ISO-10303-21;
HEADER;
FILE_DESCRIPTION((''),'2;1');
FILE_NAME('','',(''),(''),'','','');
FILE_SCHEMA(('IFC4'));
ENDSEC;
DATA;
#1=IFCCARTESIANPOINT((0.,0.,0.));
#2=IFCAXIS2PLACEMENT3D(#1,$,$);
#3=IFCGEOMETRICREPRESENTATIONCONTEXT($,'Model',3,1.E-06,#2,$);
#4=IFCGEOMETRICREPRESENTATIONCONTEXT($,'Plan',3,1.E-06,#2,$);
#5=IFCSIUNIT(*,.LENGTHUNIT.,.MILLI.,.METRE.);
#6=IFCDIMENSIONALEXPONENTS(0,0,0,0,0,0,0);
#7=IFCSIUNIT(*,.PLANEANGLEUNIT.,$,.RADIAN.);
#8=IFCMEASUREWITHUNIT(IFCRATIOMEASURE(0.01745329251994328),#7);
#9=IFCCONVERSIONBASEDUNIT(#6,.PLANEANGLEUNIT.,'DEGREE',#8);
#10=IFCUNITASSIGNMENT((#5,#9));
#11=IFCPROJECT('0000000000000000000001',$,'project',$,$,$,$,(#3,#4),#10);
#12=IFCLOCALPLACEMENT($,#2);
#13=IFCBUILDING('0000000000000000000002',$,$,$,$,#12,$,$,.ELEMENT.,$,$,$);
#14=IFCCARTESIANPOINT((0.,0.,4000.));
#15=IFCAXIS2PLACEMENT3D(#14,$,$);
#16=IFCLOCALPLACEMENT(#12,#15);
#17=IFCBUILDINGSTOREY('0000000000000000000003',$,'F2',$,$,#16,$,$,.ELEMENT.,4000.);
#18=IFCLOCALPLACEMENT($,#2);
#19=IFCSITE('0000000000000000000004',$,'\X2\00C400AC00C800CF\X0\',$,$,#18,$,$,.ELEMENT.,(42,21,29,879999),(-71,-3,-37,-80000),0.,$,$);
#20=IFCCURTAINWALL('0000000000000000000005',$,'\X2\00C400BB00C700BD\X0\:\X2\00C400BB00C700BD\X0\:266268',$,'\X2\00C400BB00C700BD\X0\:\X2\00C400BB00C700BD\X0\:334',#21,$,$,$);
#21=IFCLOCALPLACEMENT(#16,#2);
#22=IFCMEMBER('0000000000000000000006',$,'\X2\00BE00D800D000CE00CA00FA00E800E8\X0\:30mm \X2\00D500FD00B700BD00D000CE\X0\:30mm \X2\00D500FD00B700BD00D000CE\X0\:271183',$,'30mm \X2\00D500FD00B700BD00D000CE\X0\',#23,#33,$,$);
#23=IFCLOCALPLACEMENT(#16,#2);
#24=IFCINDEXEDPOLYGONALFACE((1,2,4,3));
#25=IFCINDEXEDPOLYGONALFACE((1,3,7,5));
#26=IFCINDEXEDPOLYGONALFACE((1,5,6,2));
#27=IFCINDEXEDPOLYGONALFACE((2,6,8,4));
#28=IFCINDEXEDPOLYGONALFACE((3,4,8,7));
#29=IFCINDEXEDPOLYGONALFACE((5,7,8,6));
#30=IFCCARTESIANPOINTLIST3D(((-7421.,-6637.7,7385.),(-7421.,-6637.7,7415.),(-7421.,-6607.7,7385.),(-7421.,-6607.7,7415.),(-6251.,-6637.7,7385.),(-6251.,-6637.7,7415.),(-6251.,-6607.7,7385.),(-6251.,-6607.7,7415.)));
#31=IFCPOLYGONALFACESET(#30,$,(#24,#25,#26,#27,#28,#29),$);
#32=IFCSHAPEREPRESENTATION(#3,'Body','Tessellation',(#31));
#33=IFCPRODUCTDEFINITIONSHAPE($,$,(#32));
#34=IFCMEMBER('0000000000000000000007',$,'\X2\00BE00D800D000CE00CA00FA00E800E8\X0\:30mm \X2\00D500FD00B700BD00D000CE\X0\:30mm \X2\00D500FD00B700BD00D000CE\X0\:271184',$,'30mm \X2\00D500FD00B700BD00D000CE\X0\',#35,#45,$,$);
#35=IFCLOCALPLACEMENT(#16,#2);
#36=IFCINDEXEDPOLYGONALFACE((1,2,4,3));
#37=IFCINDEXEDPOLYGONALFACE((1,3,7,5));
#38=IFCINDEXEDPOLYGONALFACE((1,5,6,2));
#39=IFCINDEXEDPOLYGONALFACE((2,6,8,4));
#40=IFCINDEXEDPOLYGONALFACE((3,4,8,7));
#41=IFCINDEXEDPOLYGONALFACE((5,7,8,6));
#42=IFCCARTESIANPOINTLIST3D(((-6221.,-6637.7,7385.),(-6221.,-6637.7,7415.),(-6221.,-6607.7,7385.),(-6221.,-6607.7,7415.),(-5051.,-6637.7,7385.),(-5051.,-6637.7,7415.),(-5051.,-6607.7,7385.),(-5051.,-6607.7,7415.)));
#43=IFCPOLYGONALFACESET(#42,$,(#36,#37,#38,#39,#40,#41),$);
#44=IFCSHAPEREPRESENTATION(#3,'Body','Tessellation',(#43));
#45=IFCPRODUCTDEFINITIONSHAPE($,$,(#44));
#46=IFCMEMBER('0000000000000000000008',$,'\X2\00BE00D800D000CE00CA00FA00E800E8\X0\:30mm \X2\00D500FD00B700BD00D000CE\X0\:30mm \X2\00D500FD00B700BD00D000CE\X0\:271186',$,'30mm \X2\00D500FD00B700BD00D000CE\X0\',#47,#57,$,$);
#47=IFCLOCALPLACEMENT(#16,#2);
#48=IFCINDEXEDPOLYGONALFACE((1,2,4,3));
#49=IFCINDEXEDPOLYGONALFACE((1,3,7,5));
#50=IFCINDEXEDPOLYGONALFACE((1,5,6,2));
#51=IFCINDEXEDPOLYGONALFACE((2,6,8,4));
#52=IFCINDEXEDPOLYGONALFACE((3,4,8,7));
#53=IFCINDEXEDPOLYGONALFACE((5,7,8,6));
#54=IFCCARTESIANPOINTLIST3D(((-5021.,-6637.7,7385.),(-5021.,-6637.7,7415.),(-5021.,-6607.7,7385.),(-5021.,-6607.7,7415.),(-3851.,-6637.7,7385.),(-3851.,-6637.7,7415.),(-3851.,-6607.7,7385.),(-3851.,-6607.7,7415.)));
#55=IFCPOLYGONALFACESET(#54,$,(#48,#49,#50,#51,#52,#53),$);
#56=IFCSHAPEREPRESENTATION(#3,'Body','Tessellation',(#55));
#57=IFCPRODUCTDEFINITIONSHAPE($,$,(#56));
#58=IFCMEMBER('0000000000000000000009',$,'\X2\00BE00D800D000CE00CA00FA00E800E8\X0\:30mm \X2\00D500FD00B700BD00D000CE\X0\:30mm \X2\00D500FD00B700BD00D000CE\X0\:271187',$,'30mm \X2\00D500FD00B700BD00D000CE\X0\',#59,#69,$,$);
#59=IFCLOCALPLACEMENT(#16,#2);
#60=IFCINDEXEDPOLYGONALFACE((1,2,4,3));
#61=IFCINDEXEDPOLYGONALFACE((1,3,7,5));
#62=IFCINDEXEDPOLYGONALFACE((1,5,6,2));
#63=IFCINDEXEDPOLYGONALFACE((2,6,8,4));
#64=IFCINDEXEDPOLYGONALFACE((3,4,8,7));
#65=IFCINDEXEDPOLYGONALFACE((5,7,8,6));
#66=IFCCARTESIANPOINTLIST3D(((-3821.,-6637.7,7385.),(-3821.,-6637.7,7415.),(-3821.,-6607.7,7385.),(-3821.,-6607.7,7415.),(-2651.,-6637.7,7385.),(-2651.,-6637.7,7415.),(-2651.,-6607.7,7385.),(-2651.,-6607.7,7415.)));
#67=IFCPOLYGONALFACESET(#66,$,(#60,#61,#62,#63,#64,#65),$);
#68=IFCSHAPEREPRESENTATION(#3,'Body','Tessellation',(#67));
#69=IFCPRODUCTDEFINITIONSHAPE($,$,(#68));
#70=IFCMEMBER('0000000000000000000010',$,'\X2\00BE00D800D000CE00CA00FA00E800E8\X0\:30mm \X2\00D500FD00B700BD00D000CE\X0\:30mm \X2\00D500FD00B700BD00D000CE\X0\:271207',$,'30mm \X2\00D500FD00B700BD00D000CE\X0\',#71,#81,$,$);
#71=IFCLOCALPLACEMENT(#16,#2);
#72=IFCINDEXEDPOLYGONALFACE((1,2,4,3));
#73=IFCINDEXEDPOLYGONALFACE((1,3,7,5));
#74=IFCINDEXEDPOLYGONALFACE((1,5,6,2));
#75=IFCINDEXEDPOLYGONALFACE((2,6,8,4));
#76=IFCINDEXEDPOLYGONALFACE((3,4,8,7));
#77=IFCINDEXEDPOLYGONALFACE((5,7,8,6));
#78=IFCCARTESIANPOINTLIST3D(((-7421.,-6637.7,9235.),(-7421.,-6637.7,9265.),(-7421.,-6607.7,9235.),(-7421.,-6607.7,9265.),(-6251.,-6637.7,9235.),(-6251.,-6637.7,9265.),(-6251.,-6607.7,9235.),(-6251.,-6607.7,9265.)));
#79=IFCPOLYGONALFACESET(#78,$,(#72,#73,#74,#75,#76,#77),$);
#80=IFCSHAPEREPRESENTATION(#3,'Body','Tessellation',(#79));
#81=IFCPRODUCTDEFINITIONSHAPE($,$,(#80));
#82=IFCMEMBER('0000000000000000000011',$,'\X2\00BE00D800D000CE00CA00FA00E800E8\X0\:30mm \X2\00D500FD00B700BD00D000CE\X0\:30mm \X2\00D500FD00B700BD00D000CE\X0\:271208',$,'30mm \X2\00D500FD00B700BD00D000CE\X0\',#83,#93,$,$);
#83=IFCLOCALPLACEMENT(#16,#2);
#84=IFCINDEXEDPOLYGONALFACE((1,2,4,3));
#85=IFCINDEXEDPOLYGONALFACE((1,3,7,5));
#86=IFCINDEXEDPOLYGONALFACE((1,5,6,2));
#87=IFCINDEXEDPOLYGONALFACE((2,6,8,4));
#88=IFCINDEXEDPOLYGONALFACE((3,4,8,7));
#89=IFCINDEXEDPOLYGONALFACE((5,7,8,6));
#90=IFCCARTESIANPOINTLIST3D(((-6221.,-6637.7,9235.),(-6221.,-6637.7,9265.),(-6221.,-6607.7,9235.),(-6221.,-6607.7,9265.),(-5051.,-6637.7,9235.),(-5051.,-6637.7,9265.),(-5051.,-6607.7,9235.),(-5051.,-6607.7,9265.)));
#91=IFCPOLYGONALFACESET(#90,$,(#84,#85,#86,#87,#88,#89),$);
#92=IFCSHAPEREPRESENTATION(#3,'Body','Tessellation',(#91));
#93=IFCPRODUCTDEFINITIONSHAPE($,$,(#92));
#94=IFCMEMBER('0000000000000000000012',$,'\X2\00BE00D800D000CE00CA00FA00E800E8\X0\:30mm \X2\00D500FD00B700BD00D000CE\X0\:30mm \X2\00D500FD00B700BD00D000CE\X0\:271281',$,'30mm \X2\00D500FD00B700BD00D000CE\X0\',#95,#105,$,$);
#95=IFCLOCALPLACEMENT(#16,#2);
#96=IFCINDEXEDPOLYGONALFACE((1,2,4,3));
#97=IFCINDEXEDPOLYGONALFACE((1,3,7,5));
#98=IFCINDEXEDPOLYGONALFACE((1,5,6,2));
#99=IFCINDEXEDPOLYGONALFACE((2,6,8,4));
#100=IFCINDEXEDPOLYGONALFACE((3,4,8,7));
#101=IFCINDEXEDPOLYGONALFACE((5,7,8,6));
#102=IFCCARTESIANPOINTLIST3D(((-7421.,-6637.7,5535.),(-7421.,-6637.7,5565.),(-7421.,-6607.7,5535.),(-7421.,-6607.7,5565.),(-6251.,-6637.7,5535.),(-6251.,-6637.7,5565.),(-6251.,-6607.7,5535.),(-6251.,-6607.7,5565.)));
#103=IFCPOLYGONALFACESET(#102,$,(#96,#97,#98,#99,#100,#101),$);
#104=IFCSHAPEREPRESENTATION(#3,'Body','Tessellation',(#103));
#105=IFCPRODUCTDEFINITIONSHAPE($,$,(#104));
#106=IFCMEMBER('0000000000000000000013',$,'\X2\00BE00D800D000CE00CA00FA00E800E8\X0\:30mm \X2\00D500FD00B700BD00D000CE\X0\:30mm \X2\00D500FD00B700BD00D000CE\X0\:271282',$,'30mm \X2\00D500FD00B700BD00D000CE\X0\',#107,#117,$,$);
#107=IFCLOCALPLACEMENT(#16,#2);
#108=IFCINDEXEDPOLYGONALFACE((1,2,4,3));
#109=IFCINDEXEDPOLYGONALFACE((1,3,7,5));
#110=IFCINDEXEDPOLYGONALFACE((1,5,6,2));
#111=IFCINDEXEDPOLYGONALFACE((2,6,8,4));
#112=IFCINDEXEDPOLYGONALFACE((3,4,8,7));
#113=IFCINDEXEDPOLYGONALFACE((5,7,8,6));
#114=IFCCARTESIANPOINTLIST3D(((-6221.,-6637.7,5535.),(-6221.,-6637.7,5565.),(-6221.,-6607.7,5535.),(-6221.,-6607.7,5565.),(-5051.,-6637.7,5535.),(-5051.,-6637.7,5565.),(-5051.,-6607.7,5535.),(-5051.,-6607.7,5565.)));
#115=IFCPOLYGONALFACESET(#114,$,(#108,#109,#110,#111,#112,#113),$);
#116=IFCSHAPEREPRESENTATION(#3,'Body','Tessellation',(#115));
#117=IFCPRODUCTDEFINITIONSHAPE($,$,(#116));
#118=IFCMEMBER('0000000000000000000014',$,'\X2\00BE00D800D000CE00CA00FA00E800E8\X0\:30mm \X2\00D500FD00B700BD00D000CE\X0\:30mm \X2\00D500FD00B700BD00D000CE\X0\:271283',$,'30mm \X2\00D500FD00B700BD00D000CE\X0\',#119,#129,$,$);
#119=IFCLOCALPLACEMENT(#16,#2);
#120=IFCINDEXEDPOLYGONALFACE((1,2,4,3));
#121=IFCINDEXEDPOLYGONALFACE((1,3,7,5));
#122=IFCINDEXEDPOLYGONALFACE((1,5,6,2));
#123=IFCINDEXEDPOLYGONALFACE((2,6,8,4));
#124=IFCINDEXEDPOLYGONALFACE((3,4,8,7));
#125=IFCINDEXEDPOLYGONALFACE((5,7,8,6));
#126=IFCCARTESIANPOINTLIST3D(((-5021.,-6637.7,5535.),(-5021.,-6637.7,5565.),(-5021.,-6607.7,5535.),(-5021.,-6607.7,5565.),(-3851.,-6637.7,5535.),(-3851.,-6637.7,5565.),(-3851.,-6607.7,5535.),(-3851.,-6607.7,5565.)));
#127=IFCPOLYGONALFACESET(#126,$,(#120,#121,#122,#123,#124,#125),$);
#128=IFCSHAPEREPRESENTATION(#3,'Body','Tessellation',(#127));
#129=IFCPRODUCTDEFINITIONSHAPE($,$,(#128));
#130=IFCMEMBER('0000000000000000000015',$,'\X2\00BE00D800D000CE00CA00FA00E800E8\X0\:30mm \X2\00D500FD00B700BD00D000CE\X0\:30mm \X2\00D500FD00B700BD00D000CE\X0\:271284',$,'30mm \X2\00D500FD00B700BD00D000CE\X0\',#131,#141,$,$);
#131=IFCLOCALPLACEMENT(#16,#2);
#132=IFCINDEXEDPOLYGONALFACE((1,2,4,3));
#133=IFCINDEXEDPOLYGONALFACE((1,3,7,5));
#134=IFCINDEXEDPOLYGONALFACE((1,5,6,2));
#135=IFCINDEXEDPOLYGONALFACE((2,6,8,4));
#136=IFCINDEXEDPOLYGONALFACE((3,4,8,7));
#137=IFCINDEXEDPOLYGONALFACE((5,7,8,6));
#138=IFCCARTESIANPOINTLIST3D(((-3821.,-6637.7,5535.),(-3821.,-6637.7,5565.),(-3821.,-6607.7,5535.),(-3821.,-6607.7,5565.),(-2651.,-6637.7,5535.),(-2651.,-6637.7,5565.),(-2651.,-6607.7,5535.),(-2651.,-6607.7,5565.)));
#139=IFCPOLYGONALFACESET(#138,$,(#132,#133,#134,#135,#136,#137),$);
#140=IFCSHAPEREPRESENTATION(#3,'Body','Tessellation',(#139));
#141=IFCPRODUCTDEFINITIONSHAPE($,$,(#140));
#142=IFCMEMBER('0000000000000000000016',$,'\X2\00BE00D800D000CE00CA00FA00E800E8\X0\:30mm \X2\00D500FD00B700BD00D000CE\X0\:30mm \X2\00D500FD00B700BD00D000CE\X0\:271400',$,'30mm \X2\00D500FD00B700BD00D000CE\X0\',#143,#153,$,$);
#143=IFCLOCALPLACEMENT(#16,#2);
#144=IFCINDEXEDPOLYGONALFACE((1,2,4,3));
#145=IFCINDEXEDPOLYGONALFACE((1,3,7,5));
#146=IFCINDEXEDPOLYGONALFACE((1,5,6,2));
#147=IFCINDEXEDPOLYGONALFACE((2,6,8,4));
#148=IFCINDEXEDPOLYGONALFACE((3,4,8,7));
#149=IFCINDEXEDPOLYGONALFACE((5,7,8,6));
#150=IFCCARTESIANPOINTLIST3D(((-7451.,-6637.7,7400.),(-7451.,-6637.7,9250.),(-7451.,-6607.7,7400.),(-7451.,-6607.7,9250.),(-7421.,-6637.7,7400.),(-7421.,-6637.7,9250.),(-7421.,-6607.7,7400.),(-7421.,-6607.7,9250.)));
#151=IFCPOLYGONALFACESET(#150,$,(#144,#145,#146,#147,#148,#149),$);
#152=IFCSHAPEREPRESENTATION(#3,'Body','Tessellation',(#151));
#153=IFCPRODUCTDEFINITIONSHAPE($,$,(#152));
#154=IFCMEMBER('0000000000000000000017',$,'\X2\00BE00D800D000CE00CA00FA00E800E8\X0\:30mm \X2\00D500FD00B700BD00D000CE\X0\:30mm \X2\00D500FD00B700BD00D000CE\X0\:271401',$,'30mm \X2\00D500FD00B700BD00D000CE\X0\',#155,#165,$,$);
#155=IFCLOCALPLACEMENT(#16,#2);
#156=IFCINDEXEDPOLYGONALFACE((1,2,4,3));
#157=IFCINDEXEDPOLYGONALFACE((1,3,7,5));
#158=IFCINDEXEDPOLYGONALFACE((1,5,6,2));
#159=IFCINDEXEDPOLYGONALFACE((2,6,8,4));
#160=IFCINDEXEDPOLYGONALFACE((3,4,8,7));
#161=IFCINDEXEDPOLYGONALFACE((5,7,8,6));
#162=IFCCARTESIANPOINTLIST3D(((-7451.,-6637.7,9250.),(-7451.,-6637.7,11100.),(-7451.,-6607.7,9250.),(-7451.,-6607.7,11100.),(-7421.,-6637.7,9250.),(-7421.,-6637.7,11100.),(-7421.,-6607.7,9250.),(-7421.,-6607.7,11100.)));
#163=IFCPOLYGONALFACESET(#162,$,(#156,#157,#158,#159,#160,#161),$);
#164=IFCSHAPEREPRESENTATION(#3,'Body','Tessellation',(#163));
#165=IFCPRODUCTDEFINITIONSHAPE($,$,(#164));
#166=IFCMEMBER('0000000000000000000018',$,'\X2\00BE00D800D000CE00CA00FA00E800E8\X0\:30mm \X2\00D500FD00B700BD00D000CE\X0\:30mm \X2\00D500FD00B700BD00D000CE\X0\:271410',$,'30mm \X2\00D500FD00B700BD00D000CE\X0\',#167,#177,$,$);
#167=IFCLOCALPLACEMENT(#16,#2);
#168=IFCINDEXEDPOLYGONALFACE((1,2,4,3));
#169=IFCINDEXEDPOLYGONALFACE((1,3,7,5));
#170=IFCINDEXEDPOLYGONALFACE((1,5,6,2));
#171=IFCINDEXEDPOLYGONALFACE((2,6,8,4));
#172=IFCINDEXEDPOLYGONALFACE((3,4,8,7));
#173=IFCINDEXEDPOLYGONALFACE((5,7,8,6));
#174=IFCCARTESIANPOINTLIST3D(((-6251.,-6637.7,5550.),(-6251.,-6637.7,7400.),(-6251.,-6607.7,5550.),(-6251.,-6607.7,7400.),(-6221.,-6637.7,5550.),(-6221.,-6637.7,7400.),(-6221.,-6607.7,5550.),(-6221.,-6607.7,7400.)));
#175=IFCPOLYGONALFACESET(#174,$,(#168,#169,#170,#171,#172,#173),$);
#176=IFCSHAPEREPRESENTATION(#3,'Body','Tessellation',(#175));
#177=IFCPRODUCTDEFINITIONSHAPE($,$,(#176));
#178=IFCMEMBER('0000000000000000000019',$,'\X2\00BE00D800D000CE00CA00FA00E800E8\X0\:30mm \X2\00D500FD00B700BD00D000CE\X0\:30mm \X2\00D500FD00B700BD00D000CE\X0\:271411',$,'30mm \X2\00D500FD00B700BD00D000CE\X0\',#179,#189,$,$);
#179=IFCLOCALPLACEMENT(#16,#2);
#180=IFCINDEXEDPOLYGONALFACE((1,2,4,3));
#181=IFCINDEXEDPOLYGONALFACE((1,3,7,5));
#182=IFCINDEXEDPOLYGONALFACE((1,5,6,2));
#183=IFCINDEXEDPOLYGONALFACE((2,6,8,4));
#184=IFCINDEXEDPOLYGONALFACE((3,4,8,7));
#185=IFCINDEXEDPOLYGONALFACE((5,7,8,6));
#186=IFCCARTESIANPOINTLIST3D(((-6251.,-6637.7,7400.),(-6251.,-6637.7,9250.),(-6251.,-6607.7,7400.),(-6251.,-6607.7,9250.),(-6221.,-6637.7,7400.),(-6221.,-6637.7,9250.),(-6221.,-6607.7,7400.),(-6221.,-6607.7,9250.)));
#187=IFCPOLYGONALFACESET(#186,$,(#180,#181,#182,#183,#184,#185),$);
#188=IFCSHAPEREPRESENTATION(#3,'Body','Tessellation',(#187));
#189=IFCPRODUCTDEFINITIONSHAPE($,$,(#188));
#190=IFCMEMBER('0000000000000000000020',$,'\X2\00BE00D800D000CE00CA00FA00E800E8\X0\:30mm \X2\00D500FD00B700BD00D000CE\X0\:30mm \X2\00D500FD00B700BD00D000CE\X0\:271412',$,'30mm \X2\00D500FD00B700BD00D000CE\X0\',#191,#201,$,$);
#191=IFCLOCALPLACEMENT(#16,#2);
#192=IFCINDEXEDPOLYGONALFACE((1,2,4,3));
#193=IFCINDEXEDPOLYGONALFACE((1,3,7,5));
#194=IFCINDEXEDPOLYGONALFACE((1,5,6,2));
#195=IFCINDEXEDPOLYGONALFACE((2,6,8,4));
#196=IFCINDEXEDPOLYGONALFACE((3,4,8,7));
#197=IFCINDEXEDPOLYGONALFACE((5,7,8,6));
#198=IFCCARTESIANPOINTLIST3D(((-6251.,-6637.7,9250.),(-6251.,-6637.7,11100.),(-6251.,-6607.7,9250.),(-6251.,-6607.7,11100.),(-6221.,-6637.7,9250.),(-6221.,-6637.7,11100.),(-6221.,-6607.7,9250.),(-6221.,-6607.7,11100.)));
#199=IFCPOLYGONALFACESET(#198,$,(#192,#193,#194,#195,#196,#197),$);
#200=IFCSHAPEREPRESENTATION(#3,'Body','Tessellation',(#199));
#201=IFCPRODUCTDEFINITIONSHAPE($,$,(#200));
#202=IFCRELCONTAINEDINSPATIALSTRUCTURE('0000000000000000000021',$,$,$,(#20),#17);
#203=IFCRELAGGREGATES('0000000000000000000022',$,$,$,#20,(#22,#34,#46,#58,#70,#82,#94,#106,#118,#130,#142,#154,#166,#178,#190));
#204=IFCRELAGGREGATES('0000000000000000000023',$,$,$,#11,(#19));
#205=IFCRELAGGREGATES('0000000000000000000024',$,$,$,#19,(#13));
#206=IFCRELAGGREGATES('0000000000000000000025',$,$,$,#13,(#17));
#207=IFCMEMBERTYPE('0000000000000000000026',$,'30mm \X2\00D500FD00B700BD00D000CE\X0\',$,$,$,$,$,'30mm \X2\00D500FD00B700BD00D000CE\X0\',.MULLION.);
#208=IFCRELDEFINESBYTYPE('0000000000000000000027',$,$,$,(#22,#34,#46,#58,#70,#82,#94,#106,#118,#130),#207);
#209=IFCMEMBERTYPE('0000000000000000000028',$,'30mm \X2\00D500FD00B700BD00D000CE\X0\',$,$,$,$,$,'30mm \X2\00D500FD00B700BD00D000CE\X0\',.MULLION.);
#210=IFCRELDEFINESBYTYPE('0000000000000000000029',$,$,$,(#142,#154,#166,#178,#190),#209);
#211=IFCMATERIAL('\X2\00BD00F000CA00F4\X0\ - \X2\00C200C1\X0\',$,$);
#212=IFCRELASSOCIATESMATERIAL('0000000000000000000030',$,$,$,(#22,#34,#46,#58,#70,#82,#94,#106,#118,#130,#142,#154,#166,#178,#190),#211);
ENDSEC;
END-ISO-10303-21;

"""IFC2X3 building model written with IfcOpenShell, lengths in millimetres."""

from ifc_helpers import new_model, entity, si_unit, converted_unit, frame, origin, origin_2d_with_axis, place, context, project, spatial, rectangle, extrude, source, transform, mapped, material, type_object, type_shapes, element, aggregate, save


model = new_model("IFC2X3")

# Units and contexts
model_context = context("Model", 3, precision=1e-06, world=origin())
plan_context = context("Plan", 3, precision=1e-06, world=origin())
ifc_project = project(units=[si_unit("LENGTHUNIT", "METRE", prefix="MILLI"), converted_unit("PLANEANGLEUNIT", "DEGREE", entity("IfcRatioMeasure", 0.01745329251994328), si_unit("PLANEANGLEUNIT", "RADIAN"), dimensions=[0, 0, 0, 0, 0, 0, 0])], contexts=[model_context, plan_context])

# Site, building, storey
site_placement = place(None, origin())
site = spatial("IfcSite", under=ifc_project, at=site_placement, Name="Ä¬ÈÏ", CompositionType="ELEMENT", RefLatitude=(42, 21, 29, 879999), RefLongitude=(-71, -3, -37, -80000), RefElevation=0.0)
building_placement = place(None, origin())
building = spatial("IfcBuilding", under=site, at=building_placement, CompositionType="ELEMENT")
storey_placement = place(building_placement, frame((0.0, 0.0, 4000.0)))
storey = spatial("IfcBuildingStorey", under=building, at=storey_placement, Name="F2", CompositionType="ELEMENT", Elevation=4000.0)

# Curtain wall, members
curtain_wall_placement = place(storey_placement, origin())
curtain_wall = element("IfcCurtainWall", 1, at=curtain_wall_placement, inside=storey, Name="Ä»Ç½:Ä»Ç½:266268", ObjectType="Ä»Ç½:Ä»Ç½:334")
ifc_material_1 = material(Name="½ðÊô - ÂÁ")
member_type_1 = type_object("IfcMemberType", Name="30mm Õý·½ÐÎ", ElementType="30mm Õý·½ÐÎ", PredefinedType="MULLION")
shared_shape_1 = source(origin(), model_context, "Body", "SweptSolid", [
    extrude(rectangle(XDim=30.0, YDim=30.0, at=origin_2d_with_axis()), frame((0.0, 0.0, -1170.0), z_axis=(0.0, 0.0, 1.0), x_axis=(-1.0, 0.0, 0.0)), (0.0, 0.0, 1.0), 1170.0),
])
type_shapes(member_type_1, [shared_shape_1])
placement_1 = place(building_placement, frame((0.0, 0.0, 11400.0)))
member_1_placement = place(placement_1, frame((-6251.0, -6622.7, 0.0), z_axis=(1.0, 0.0, 0.0), x_axis=(0.0, 0.0, 1.0)))
member_1 = element("IfcMember", 2, at=member_1_placement, type_object=member_type_1, material=ifc_material_1, Name="¾ØÐÎÊúèè:30mm Õý·½ÐÎ:30mm Õý·½ÐÎ:271183", ObjectType="30mm Õý·½ÐÎ", context=model_context, shape_type="MappedRepresentation", body=[
    mapped(shared_shape_1, transform((0.0, 0.0, 0.0), scale=1.0)),
])
member_2_placement = place(placement_1, frame((-5051.0, -6622.7, 0.0), z_axis=(1.0, 0.0, 0.0), x_axis=(0.0, 0.0, 1.0)))
member_2 = element("IfcMember", 3, at=member_2_placement, type_object=member_type_1, material=ifc_material_1, Name="¾ØÐÎÊúèè:30mm Õý·½ÐÎ:30mm Õý·½ÐÎ:271184", ObjectType="30mm Õý·½ÐÎ", context=model_context, shape_type="MappedRepresentation", body=[
    mapped(shared_shape_1, transform((0.0, 0.0, 0.0), scale=1.0)),
])
member_3_placement = place(placement_1, frame((-3851.0, -6622.7, 0.0), z_axis=(1.0, 0.0, 0.0), x_axis=(0.0, 0.0, 1.0)))
member_3 = element("IfcMember", 4, at=member_3_placement, type_object=member_type_1, material=ifc_material_1, Name="¾ØÐÎÊúèè:30mm Õý·½ÐÎ:30mm Õý·½ÐÎ:271186", ObjectType="30mm Õý·½ÐÎ", context=model_context, shape_type="MappedRepresentation", body=[
    mapped(shared_shape_1, transform((0.0, 0.0, 0.0), scale=1.0)),
])
member_4_placement = place(placement_1, frame((-2651.0, -6622.7, 0.0), z_axis=(1.0, 0.0, 0.0), x_axis=(0.0, 0.0, 1.0)))
member_4 = element("IfcMember", 5, at=member_4_placement, type_object=member_type_1, material=ifc_material_1, Name="¾ØÐÎÊúèè:30mm Õý·½ÐÎ:30mm Õý·½ÐÎ:271187", ObjectType="30mm Õý·½ÐÎ", context=model_context, shape_type="MappedRepresentation", body=[
    mapped(shared_shape_1, transform((0.0, 0.0, 0.0), scale=1.0)),
])
member_5_placement = place(placement_1, frame((-6251.0, -6622.7, 1850.0), z_axis=(1.0, 0.0, 0.0), x_axis=(0.0, 0.0, 1.0)))
member_5 = element("IfcMember", 6, at=member_5_placement, type_object=member_type_1, material=ifc_material_1, Name="¾ØÐÎÊúèè:30mm Õý·½ÐÎ:30mm Õý·½ÐÎ:271207", ObjectType="30mm Õý·½ÐÎ", context=model_context, shape_type="MappedRepresentation", body=[
    mapped(shared_shape_1, transform((0.0, 0.0, 0.0), scale=1.0)),
])
member_6_placement = place(placement_1, frame((-5051.0, -6622.7, 1850.0), z_axis=(1.0, 0.0, 0.0), x_axis=(0.0, 0.0, 1.0)))
member_6 = element("IfcMember", 7, at=member_6_placement, type_object=member_type_1, material=ifc_material_1, Name="¾ØÐÎÊúèè:30mm Õý·½ÐÎ:30mm Õý·½ÐÎ:271208", ObjectType="30mm Õý·½ÐÎ", context=model_context, shape_type="MappedRepresentation", body=[
    mapped(shared_shape_1, transform((0.0, 0.0, 0.0), scale=1.0)),
])
placement_2 = place(building_placement, frame((0.0, 0.0, 7700.0)))
member_7_placement = place(placement_2, frame((-6251.0, -6622.7, 1850.0), z_axis=(1.0, 0.0, 0.0), x_axis=(0.0, 0.0, 1.0)))
member_7 = element("IfcMember", 8, at=member_7_placement, type_object=member_type_1, material=ifc_material_1, Name="¾ØÐÎÊúèè:30mm Õý·½ÐÎ:30mm Õý·½ÐÎ:271281", ObjectType="30mm Õý·½ÐÎ", context=model_context, shape_type="MappedRepresentation", body=[
    mapped(shared_shape_1, transform((0.0, 0.0, 0.0), scale=1.0)),
])
member_8_placement = place(placement_2, frame((-5051.0, -6622.7, 1850.0), z_axis=(1.0, 0.0, 0.0), x_axis=(0.0, 0.0, 1.0)))
member_8 = element("IfcMember", 9, at=member_8_placement, type_object=member_type_1, material=ifc_material_1, Name="¾ØÐÎÊúèè:30mm Õý·½ÐÎ:30mm Õý·½ÐÎ:271282", ObjectType="30mm Õý·½ÐÎ", context=model_context, shape_type="MappedRepresentation", body=[
    mapped(shared_shape_1, transform((0.0, 0.0, 0.0), scale=1.0)),
])
member_9_placement = place(placement_2, frame((-3851.0, -6622.7, 1850.0), z_axis=(1.0, 0.0, 0.0), x_axis=(0.0, 0.0, 1.0)))
member_9 = element("IfcMember", 10, at=member_9_placement, type_object=member_type_1, material=ifc_material_1, Name="¾ØÐÎÊúèè:30mm Õý·½ÐÎ:30mm Õý·½ÐÎ:271283", ObjectType="30mm Õý·½ÐÎ", context=model_context, shape_type="MappedRepresentation", body=[
    mapped(shared_shape_1, transform((0.0, 0.0, 0.0), scale=1.0)),
])
member_10_placement = place(placement_2, frame((-2651.0, -6622.7, 1850.0), z_axis=(1.0, 0.0, 0.0), x_axis=(0.0, 0.0, 1.0)))
member_10 = element("IfcMember", 11, at=member_10_placement, type_object=member_type_1, material=ifc_material_1, Name="¾ØÐÎÊúèè:30mm Õý·½ÐÎ:30mm Õý·½ÐÎ:271284", ObjectType="30mm Õý·½ÐÎ", context=model_context, shape_type="MappedRepresentation", body=[
    mapped(shared_shape_1, transform((0.0, 0.0, 0.0), scale=1.0)),
])
member_type_2 = type_object("IfcMemberType", Name="30mm Õý·½ÐÎ", ElementType="30mm Õý·½ÐÎ", PredefinedType="MULLION")
shared_shape_2 = source(origin(), model_context, "Body", "SweptSolid", [
    extrude(rectangle(XDim=30.0, YDim=30.0, at=origin_2d_with_axis()), frame((0.0, 0.0, -1850.0), z_axis=(0.0, 0.0, 1.0), x_axis=(-1.0, 0.0, 0.0)), (0.0, 0.0, 1.0), 1850.0),
])
type_shapes(member_type_2, [shared_shape_2])
member_11_placement = place(placement_1, frame((-7436.0, -6622.7, 0.0), z_axis=(0.0, 0.0, -1.0), x_axis=(1.0, 0.0, 0.0)))
member_11 = element("IfcMember", 12, at=member_11_placement, type_object=member_type_2, material=ifc_material_1, Name="¾ØÐÎÊúèè:30mm Õý·½ÐÎ:30mm Õý·½ÐÎ:271400", ObjectType="30mm Õý·½ÐÎ", context=model_context, shape_type="MappedRepresentation", body=[
    mapped(shared_shape_2, transform((0.0, 0.0, 0.0), scale=1.0)),
])
member_12_placement = place(placement_1, frame((-7436.0, -6622.7, 1850.0), z_axis=(0.0, 0.0, -1.0), x_axis=(1.0, 0.0, 0.0)))
member_12 = element("IfcMember", 13, at=member_12_placement, type_object=member_type_2, material=ifc_material_1, Name="¾ØÐÎÊúèè:30mm Õý·½ÐÎ:30mm Õý·½ÐÎ:271401", ObjectType="30mm Õý·½ÐÎ", context=model_context, shape_type="MappedRepresentation", body=[
    mapped(shared_shape_2, transform((0.0, 0.0, 0.0), scale=1.0)),
])
member_13_placement = place(placement_2, frame((-6236.0, -6622.7, 1850.0), z_axis=(0.0, 0.0, -1.0), x_axis=(1.0, 0.0, 0.0)))
member_13 = element("IfcMember", 14, at=member_13_placement, type_object=member_type_2, material=ifc_material_1, Name="¾ØÐÎÊúèè:30mm Õý·½ÐÎ:30mm Õý·½ÐÎ:271410", ObjectType="30mm Õý·½ÐÎ", context=model_context, shape_type="MappedRepresentation", body=[
    mapped(shared_shape_2, transform((0.0, 0.0, 0.0), scale=1.0)),
])
member_14_placement = place(placement_1, frame((-6236.0, -6622.7, 0.0), z_axis=(0.0, 0.0, -1.0), x_axis=(1.0, 0.0, 0.0)))
member_14 = element("IfcMember", 15, at=member_14_placement, type_object=member_type_2, material=ifc_material_1, Name="¾ØÐÎÊúèè:30mm Õý·½ÐÎ:30mm Õý·½ÐÎ:271411", ObjectType="30mm Õý·½ÐÎ", context=model_context, shape_type="MappedRepresentation", body=[
    mapped(shared_shape_2, transform((0.0, 0.0, 0.0), scale=1.0)),
])
member_15_placement = place(placement_1, frame((-6236.0, -6622.7, 1850.0), z_axis=(0.0, 0.0, -1.0), x_axis=(1.0, 0.0, 0.0)))
member_15 = element("IfcMember", 16, at=member_15_placement, type_object=member_type_2, material=ifc_material_1, Name="¾ØÐÎÊúèè:30mm Õý·½ÐÎ:30mm Õý·½ÐÎ:271412", ObjectType="30mm Õý·½ÐÎ", context=model_context, shape_type="MappedRepresentation", body=[
    mapped(shared_shape_2, transform((0.0, 0.0, 0.0), scale=1.0)),
])
aggregate(curtain_wall, [member_1, member_2, member_3, member_4, member_5, member_6, member_7, member_8, member_9, member_10, member_11, member_12, member_13, member_14, member_15])

save(model, "model.ifc")
